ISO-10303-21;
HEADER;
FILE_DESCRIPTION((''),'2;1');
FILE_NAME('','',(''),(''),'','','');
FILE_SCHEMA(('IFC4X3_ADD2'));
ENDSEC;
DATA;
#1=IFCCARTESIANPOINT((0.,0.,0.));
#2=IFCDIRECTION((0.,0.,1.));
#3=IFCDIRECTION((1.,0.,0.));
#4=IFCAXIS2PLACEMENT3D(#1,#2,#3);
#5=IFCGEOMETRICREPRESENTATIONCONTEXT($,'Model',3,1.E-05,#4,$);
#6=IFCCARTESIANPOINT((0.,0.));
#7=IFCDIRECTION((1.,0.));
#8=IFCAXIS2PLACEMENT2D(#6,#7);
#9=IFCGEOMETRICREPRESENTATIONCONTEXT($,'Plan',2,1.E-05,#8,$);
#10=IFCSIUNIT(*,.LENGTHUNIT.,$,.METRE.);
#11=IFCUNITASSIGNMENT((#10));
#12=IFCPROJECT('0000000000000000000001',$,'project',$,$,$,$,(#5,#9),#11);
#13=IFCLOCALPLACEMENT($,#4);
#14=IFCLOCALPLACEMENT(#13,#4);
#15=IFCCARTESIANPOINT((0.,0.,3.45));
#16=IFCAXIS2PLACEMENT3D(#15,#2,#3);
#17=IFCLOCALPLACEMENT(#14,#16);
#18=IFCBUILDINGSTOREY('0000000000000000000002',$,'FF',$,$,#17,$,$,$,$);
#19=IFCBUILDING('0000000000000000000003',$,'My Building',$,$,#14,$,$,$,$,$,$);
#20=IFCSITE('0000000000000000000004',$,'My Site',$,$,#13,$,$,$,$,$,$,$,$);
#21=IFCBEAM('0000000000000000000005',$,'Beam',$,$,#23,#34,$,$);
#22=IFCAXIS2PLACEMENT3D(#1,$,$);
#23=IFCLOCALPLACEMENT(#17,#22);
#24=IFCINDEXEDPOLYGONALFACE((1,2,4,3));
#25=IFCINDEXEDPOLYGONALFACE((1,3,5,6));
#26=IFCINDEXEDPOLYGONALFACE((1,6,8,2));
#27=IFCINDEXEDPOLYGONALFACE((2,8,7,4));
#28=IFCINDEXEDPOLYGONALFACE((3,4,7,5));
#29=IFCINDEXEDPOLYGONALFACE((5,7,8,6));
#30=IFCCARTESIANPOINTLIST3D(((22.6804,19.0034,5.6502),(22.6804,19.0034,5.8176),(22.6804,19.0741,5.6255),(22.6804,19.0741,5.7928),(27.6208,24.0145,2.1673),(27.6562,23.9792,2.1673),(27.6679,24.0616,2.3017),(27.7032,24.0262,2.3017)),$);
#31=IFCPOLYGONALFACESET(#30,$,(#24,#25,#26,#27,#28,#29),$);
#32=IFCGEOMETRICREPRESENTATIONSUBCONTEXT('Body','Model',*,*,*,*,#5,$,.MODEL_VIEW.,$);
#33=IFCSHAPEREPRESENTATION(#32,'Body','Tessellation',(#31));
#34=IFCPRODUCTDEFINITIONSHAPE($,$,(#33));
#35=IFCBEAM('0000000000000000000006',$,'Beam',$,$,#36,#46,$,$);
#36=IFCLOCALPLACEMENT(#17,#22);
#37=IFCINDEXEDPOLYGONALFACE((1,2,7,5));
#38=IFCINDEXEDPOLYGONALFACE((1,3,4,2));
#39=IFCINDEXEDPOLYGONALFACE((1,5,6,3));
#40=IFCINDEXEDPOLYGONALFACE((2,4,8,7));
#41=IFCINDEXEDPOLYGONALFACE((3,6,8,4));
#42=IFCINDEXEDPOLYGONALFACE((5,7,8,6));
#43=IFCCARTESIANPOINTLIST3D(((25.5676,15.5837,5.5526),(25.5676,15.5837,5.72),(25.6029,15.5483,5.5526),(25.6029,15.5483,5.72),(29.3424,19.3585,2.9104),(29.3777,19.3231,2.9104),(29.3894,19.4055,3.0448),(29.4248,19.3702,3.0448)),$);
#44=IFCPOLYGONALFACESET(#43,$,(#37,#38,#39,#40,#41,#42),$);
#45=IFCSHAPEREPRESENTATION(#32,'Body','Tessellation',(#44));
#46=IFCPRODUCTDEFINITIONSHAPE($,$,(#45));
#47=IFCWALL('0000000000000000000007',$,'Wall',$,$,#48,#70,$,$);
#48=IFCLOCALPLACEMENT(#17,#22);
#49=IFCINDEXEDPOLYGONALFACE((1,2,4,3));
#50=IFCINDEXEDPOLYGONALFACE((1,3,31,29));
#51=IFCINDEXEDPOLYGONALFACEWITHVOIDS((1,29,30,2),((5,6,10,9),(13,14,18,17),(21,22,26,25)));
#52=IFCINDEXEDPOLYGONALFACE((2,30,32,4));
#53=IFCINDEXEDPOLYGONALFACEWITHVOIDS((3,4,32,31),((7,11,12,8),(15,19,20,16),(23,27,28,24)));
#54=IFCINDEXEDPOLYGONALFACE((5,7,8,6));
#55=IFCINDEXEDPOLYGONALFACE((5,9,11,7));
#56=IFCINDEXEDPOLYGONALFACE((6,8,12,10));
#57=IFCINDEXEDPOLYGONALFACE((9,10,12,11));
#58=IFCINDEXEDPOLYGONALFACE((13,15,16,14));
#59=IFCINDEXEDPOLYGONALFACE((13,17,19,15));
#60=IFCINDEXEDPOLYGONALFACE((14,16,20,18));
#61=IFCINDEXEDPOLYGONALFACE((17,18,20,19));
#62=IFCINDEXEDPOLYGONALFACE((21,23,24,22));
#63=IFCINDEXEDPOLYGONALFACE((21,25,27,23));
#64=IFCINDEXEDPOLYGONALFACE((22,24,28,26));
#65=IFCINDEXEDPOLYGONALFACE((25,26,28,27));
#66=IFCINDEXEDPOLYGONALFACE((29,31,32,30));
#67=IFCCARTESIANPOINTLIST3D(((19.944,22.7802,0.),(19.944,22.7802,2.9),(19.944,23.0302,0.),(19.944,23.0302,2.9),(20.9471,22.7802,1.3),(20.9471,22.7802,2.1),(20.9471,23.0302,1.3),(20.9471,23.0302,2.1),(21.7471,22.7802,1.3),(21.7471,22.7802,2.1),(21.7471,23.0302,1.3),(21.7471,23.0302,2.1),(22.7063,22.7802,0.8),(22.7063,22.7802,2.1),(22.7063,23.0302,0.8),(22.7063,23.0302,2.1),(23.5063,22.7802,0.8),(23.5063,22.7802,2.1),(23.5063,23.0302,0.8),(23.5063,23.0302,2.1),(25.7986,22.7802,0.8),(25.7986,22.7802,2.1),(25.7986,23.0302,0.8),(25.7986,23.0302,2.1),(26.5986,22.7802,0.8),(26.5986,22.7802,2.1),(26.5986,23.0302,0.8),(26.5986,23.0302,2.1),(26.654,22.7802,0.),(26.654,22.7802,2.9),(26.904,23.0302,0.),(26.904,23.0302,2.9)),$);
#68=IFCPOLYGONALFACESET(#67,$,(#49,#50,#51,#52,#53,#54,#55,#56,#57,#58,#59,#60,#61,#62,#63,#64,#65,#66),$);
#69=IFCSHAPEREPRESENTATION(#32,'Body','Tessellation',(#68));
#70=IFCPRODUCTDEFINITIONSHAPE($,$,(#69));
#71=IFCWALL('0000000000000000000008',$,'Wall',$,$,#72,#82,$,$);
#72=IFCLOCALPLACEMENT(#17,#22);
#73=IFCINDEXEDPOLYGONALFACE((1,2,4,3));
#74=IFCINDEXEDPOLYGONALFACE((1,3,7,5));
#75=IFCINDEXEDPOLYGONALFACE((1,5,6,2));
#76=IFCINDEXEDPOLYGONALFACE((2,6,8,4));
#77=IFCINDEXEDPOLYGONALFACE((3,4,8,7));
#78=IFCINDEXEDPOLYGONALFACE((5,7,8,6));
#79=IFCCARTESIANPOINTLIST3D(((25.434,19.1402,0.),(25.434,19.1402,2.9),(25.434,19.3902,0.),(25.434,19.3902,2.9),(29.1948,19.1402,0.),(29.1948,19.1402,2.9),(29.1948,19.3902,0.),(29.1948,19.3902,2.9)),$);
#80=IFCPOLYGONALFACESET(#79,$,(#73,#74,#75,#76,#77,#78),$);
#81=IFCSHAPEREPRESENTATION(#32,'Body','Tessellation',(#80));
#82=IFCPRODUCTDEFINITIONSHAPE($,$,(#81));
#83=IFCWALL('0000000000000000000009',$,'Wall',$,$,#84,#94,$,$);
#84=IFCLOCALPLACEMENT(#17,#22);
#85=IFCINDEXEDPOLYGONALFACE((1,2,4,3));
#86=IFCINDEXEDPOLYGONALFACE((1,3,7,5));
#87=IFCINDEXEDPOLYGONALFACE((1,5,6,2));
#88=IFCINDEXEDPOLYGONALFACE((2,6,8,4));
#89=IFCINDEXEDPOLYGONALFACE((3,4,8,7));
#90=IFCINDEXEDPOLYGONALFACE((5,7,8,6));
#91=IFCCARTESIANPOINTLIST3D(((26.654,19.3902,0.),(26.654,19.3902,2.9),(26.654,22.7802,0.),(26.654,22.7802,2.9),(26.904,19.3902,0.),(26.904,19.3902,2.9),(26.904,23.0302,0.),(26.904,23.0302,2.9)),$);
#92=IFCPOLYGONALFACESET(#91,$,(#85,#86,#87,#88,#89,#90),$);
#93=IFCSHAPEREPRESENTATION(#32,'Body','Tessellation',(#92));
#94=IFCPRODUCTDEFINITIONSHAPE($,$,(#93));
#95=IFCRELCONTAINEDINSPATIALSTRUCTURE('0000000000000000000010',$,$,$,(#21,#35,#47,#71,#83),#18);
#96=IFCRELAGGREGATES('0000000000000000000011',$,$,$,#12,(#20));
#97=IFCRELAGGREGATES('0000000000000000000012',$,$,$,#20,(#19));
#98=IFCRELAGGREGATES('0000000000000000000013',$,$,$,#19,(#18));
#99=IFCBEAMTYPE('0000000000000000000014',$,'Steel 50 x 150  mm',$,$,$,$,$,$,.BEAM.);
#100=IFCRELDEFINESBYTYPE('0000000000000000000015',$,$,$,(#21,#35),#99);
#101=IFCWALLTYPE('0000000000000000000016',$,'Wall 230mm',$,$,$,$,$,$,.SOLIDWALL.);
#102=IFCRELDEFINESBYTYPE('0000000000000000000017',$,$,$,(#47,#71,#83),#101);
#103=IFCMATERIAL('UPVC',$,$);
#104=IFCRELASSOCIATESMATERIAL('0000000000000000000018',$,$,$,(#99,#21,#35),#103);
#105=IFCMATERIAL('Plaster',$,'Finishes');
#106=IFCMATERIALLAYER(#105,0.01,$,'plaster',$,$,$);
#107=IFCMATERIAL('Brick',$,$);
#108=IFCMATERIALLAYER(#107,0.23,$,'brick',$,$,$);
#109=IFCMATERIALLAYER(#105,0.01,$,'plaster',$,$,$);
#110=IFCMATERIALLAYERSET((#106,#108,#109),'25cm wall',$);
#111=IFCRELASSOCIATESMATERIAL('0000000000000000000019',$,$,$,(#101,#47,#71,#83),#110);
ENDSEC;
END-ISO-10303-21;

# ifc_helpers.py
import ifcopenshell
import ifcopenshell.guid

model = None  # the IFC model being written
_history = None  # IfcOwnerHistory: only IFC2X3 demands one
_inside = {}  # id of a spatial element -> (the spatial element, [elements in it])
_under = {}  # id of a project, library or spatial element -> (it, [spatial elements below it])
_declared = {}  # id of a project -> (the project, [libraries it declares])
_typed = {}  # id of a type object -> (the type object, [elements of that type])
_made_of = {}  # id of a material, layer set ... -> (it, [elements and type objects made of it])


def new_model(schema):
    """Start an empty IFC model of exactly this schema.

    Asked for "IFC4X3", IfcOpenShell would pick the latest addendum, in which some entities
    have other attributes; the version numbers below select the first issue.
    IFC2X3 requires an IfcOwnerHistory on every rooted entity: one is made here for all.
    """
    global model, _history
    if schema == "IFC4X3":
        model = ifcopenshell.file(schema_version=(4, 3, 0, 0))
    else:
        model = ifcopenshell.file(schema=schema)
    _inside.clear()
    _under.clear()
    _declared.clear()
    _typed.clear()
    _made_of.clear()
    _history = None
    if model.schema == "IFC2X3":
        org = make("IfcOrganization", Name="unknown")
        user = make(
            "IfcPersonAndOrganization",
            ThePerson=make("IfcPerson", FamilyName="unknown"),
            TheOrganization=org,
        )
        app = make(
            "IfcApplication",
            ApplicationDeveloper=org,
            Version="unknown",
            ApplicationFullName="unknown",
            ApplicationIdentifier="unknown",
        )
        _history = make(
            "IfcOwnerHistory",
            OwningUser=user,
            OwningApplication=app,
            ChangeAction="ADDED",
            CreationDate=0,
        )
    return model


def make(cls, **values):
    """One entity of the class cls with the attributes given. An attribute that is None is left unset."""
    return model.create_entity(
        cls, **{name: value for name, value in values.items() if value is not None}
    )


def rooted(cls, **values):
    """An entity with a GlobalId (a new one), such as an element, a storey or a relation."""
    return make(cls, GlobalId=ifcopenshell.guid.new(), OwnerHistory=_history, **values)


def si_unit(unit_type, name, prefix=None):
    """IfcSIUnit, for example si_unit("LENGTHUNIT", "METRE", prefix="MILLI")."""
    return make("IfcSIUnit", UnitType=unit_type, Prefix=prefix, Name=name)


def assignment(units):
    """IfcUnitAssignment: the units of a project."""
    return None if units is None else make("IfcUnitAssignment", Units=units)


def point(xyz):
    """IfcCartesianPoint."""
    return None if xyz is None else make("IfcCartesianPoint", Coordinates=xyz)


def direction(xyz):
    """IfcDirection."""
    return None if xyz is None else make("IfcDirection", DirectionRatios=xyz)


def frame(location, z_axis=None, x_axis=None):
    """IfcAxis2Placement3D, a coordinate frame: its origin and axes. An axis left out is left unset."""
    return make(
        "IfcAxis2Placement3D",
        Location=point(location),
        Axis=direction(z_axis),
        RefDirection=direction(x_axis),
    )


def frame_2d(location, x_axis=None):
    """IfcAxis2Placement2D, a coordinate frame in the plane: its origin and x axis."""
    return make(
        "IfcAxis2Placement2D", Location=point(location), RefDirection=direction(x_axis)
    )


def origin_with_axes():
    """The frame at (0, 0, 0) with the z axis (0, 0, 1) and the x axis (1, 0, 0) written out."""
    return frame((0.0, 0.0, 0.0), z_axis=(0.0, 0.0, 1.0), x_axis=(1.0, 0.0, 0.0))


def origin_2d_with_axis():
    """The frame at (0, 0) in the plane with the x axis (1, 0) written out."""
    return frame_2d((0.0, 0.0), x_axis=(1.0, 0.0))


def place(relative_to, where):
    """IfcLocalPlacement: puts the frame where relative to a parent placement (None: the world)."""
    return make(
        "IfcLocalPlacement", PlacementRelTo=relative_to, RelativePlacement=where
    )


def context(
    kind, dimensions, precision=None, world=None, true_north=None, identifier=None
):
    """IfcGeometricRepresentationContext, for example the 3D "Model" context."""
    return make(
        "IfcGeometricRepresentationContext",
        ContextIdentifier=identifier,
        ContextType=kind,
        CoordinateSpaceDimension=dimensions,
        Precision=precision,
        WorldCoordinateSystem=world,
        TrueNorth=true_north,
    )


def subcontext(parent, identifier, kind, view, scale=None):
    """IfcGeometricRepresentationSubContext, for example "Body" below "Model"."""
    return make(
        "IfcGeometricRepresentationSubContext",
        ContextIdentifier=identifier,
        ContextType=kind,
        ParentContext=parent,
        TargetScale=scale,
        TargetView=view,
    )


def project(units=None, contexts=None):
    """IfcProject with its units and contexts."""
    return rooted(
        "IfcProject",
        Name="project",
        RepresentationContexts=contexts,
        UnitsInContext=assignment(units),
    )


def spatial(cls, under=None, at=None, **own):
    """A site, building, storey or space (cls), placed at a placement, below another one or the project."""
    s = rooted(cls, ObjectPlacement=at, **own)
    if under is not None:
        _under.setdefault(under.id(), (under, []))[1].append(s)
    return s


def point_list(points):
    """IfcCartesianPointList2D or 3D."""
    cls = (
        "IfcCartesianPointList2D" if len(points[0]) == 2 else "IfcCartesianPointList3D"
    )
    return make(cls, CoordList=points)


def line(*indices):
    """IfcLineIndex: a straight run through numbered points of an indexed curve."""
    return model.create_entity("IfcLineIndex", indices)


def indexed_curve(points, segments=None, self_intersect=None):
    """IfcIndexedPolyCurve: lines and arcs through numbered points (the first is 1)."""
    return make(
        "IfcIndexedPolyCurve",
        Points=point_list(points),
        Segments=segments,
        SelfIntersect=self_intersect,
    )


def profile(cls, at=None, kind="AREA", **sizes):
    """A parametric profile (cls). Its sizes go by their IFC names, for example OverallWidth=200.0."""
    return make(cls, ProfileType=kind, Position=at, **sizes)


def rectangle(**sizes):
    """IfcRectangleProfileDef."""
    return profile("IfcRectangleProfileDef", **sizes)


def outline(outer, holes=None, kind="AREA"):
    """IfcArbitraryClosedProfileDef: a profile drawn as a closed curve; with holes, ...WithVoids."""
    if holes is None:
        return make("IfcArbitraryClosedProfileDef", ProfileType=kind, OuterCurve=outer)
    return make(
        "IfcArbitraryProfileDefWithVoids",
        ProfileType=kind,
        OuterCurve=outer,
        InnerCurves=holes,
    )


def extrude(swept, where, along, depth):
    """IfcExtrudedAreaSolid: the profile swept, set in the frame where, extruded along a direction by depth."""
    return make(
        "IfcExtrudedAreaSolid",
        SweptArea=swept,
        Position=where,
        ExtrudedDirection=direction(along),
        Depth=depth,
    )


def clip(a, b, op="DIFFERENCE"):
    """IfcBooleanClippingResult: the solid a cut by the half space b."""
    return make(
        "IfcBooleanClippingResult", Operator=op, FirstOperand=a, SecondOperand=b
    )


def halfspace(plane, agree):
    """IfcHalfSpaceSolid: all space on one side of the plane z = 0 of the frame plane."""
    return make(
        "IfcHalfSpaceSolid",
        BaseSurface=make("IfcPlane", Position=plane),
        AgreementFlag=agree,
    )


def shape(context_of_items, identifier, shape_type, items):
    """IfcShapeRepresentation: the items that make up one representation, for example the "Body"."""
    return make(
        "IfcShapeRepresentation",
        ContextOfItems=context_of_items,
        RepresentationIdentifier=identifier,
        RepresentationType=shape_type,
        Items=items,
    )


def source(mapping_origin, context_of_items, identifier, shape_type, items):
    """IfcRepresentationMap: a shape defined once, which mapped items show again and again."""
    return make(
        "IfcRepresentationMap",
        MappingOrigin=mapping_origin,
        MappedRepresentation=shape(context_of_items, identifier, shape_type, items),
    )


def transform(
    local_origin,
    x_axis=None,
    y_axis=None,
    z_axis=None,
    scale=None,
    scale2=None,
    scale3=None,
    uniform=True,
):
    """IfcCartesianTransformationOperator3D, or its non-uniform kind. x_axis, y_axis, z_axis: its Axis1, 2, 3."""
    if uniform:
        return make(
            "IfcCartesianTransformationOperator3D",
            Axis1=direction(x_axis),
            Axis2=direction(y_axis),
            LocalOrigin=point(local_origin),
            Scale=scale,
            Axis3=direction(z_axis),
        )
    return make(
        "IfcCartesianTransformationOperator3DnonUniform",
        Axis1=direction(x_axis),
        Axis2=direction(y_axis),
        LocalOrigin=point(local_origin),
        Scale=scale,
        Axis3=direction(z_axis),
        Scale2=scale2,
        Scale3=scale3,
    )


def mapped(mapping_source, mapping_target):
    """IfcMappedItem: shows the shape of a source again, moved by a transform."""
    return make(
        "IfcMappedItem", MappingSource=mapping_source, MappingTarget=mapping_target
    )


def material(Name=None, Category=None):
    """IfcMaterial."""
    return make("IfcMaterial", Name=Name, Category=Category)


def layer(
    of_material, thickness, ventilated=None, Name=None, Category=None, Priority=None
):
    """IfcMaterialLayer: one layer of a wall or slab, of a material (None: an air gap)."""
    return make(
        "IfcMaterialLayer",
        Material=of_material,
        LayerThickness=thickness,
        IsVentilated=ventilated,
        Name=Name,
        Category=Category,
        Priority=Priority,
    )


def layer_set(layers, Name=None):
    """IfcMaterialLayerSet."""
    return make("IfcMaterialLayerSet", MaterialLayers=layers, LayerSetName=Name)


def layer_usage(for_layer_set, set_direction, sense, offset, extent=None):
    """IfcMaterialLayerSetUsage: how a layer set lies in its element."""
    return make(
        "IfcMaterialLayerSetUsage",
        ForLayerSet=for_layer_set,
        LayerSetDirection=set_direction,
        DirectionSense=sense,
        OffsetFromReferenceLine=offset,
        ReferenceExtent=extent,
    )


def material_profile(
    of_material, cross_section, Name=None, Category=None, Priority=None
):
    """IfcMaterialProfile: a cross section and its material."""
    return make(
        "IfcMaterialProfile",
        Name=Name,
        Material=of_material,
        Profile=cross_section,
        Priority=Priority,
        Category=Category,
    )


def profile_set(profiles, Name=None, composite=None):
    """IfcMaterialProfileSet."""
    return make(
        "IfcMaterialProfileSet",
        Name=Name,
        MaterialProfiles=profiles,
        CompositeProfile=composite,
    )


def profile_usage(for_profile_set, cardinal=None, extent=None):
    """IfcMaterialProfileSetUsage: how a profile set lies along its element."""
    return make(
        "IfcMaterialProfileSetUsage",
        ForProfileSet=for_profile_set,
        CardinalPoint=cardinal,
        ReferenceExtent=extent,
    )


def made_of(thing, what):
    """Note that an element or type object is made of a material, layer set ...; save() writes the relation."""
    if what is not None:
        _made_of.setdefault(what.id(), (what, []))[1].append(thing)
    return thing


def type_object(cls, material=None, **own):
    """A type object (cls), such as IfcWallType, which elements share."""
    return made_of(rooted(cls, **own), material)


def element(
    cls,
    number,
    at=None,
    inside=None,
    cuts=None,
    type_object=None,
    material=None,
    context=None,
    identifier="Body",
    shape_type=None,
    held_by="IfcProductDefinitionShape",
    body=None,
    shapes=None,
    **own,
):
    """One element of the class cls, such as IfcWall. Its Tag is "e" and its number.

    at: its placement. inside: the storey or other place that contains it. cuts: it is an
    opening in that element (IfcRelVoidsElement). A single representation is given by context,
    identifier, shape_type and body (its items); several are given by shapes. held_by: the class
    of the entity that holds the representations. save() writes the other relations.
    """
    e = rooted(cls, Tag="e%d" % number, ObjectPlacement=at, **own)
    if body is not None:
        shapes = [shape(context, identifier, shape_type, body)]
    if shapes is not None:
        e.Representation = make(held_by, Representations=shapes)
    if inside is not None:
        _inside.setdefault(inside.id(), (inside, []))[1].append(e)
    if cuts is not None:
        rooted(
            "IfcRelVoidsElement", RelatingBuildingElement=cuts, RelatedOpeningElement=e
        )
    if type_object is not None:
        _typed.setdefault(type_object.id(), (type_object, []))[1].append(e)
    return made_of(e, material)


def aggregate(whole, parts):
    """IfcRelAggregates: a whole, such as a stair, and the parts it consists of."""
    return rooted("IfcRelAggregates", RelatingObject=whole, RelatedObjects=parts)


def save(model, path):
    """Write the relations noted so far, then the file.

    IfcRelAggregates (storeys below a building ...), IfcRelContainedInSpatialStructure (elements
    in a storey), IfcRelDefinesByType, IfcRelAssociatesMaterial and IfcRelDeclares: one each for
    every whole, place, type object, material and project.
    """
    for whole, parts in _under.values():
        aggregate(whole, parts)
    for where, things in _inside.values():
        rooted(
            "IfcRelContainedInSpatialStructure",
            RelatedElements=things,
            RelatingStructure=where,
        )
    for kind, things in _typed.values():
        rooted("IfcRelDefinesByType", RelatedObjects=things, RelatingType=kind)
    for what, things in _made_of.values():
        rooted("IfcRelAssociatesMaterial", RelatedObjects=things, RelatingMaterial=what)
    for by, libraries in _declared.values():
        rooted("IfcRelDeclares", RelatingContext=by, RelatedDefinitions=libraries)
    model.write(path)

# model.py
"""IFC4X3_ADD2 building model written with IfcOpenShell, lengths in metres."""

from ifc_helpers import new_model, si_unit, frame, origin_with_axes, origin_2d_with_axis, place, context, subcontext, project, spatial, line, indexed_curve, rectangle, outline, extrude, clip, halfspace, source, transform, mapped, material, layer, layer_set, layer_usage, material_profile, profile_set, profile_usage, type_object, element, save


model = new_model("IFC4X3_ADD2")

# Units and contexts
model_context = context("Model", 3, precision=1e-05, world=origin_with_axes())
plan_context = context("Plan", 2, precision=1e-05, world=origin_2d_with_axis())
body_context_1 = subcontext(model_context, "Body", "Model", "MODEL_VIEW")
ifc_project = project(units=[si_unit("LENGTHUNIT", "METRE")], contexts=[model_context, plan_context])

# Site, building, storey
site_placement = place(None, origin_with_axes())
site = spatial("IfcSite", under=ifc_project, at=site_placement, Name="My Site")
building_placement = place(site_placement, origin_with_axes())
building = spatial("IfcBuilding", under=site, at=building_placement, Name="My Building")
storey_placement = place(building_placement, frame((0.0, 0.0, 3.45), z_axis=(0.0, 0.0, 1.0), x_axis=(1.0, 0.0, 0.0)))
storey = spatial("IfcBuildingStorey", under=building, at=storey_placement, Name="FF")

# Beams
ifc_material_1 = material(Name="UPVC")
ifc_material_profile = material_profile(ifc_material_1, rectangle(XDim=0.05, YDim=0.15))
ifc_profile_set = profile_set([ifc_material_profile])
ifc_profile_usage_1 = profile_usage(ifc_profile_set)
beam_type = type_object("IfcBeamType", Name="Steel 50 x 150  mm", PredefinedType="BEAM", material=ifc_profile_set)
beam_1_placement = place(storey_placement, frame((27.662, 24.0204, 2.2345), z_axis=(-0.633729, -0.633729, 0.443593), x_axis=(0.707107, -0.707107, 0.0)))
element("IfcBeam", 1, at=beam_1_placement, inside=storey, type_object=beam_type, material=ifc_profile_usage_1, Name="Beam", context=body_context_1, shape_type="Clipping", body=[
    clip(extrude(rectangle(XDim=0.05, YDim=0.15), origin_with_axes(), (0.0, 0.0, 1.0), 8.0387), halfspace(frame((0.025, -8.2743, 3.7933), z_axis=(-0.707107, -0.313667, 0.633729), x_axis=(-0.405488, 0.9141, 0.0)), False)),
])
ifc_profile_usage_2 = profile_usage(ifc_profile_set)
beam_2_placement = place(storey_placement, frame((29.3836, 19.3643, 2.9776), z_axis=(-0.633729, -0.633729, 0.443593), x_axis=(0.707107, -0.707107, 0.0)))
element("IfcBeam", 2, at=beam_2_placement, inside=storey, type_object=beam_type, material=ifc_profile_usage_2, Name="Beam", context=body_context_1, shape_type="Clipping", body=[
    clip(extrude(rectangle(XDim=0.05, YDim=0.15), origin_with_axes(), (0.0, 0.0, 1.0), 6.1436), halfspace(frame((10.182, -4.5881, 3.7227), z_axis=(0.0, -0.443593, 0.896228), x_axis=(-1.0, -0.000001, 0.0)), False)),
])

# Wall, openings
ifc_material_2 = material(Name="Plaster", Category="Finishes")
ifc_layer_1 = layer(ifc_material_2, 0.01, Name="plaster")
ifc_material_3 = material(Name="Brick")
ifc_layer_2 = layer(ifc_material_3, 0.23, Name="brick")
ifc_layer_3 = layer(ifc_material_2, 0.01, Name="plaster")
ifc_layer_set = layer_set([ifc_layer_1, ifc_layer_2, ifc_layer_3], Name="25cm wall")
ifc_layer_usage_1 = layer_usage(ifc_layer_set, "AXIS2", "POSITIVE", 0.0)
wall_type = type_object("IfcWallType", Name="Wall 230mm", PredefinedType="SOLIDWALL", material=ifc_layer_set)
wall_1_placement = place(storey_placement, frame((26.904, 23.0302, 0.0), z_axis=(0.0, 0.0, 1.0), x_axis=(-1.0, 0.0, 0.0)))
wall_1 = element("IfcWall", 3, at=wall_1_placement, inside=storey, type_object=wall_type, material=ifc_layer_usage_1, Name="Wall", context=body_context_1, shape_type="SweptSolid", body=[
    extrude(outline(indexed_curve([(0.0, 0.0), (0.25, 0.25), (6.96, 0.25), (6.96, 0.0)], segments=[line(1, 2, 3, 4, 1)])), origin_with_axes(), (0.0, 0.0, 1.0), 2.9),
])
shared_shape_1 = source(origin_with_axes(), body_context_1, "Body", "SweptSolid", [
    extrude(outline(indexed_curve([(0.0, 0.0), (0.8, 0.0), (0.8, 1.3), (0.0, 1.3)], segments=[line(1, 2, 3, 4, 1)])), frame((-0.4, -0.6, 0.0), z_axis=(0.0, -1.0, 0.0), x_axis=(1.0, 0.0, 0.0)), (0.0, 0.0, -1.0), 1.2),
])
opening_1_placement = place(wall_1_placement, frame((3.7977, 0.0, 0.8), z_axis=(0.0, 0.0, 1.0), x_axis=(1.0, 0.0, 0.0)))
element("IfcOpeningElement", 4, at=opening_1_placement, cuts=wall_1, PredefinedType="OPENING", context=body_context_1, shape_type="MappedRepresentation", body=[
    mapped(shared_shape_1, transform((0.0, 0.0, 0.0), x_axis=(1.0, 0.0, 0.0), y_axis=(0.0, 1.0, 0.0), z_axis=(0.0, 0.0, 1.0), scale=1.0)),
])
shared_shape_2 = source(origin_with_axes(), body_context_1, "Body", "SweptSolid", [
    extrude(outline(indexed_curve([(0.0, 0.0), (0.8, 0.0), (0.8, 0.8), (0.0, 0.8)], segments=[line(1, 2, 3, 4, 1)])), frame((-0.4, -0.6, 0.0), z_axis=(0.0, -1.0, 0.0), x_axis=(1.0, 0.0, 0.0)), (0.0, 0.0, -1.0), 1.2),
])
opening_2_placement = place(wall_1_placement, frame((5.5569, 0.0, 1.3), z_axis=(0.0, 0.0, 1.0), x_axis=(1.0, 0.0, 0.0)))
element("IfcOpeningElement", 5, at=opening_2_placement, cuts=wall_1, PredefinedType="OPENING", context=body_context_1, shape_type="MappedRepresentation", body=[
    mapped(shared_shape_2, transform((0.0, 0.0, 0.0), x_axis=(1.0, 0.0, 0.0), y_axis=(0.0, 1.0, 0.0), z_axis=(0.0, 0.0, 1.0), scale=1.0)),
])
opening_3_placement = place(wall_1_placement, frame((0.7053, 0.0, 0.8), z_axis=(0.0, 0.0, 1.0), x_axis=(1.0, 0.0, 0.0)))
element("IfcOpeningElement", 6, at=opening_3_placement, cuts=wall_1, PredefinedType="OPENING", context=body_context_1, shape_type="MappedRepresentation", body=[
    mapped(shared_shape_1, transform((0.0, 0.0, 0.0), x_axis=(1.0, 0.0, 0.0), y_axis=(0.0, 1.0, 0.0), z_axis=(0.0, 0.0, 1.0), scale=1.0)),
])

# Walls
ifc_layer_usage_2 = layer_usage(ifc_layer_set, "AXIS2", "NEGATIVE", 0.0)
wall_2_placement = place(storey_placement, frame((29.1948, 19.1402, 0.0), z_axis=(0.0, 0.0, 1.0), x_axis=(-1.0, 0.0, 0.0)))
element("IfcWall", 7, at=wall_2_placement, inside=storey, type_object=wall_type, material=ifc_layer_usage_2, Name="Wall", context=body_context_1, shape_type="SweptSolid", body=[
    extrude(outline(indexed_curve([(0.0, -0.25), (0.0, 0.0), (3.7608, 0.0), (3.7608, -0.25)], segments=[line(1, 2, 3, 4, 1)])), origin_with_axes(), (0.0, 0.0, 1.0), 2.9),
])
ifc_layer_usage_3 = layer_usage(ifc_layer_set, "AXIS2", "POSITIVE", 0.0)
wall_3_placement = place(storey_placement, frame((26.904, 19.1402, 0.0), z_axis=(0.0, 0.0, 1.0), x_axis=(0.000001, 1.0, 0.0)))
element("IfcWall", 8, at=wall_3_placement, inside=storey, type_object=wall_type, material=ifc_layer_usage_3, Name="Wall", context=body_context_1, shape_type="SweptSolid", body=[
    extrude(outline(indexed_curve([(0.25, 0.0), (0.25, 0.25), (3.64, 0.25), (3.89, 0.0)], segments=[line(1, 2, 3, 4, 1)])), origin_with_axes(), (0.0, 0.0, 1.0), 2.9),
])

save(model, "model.ifc")
